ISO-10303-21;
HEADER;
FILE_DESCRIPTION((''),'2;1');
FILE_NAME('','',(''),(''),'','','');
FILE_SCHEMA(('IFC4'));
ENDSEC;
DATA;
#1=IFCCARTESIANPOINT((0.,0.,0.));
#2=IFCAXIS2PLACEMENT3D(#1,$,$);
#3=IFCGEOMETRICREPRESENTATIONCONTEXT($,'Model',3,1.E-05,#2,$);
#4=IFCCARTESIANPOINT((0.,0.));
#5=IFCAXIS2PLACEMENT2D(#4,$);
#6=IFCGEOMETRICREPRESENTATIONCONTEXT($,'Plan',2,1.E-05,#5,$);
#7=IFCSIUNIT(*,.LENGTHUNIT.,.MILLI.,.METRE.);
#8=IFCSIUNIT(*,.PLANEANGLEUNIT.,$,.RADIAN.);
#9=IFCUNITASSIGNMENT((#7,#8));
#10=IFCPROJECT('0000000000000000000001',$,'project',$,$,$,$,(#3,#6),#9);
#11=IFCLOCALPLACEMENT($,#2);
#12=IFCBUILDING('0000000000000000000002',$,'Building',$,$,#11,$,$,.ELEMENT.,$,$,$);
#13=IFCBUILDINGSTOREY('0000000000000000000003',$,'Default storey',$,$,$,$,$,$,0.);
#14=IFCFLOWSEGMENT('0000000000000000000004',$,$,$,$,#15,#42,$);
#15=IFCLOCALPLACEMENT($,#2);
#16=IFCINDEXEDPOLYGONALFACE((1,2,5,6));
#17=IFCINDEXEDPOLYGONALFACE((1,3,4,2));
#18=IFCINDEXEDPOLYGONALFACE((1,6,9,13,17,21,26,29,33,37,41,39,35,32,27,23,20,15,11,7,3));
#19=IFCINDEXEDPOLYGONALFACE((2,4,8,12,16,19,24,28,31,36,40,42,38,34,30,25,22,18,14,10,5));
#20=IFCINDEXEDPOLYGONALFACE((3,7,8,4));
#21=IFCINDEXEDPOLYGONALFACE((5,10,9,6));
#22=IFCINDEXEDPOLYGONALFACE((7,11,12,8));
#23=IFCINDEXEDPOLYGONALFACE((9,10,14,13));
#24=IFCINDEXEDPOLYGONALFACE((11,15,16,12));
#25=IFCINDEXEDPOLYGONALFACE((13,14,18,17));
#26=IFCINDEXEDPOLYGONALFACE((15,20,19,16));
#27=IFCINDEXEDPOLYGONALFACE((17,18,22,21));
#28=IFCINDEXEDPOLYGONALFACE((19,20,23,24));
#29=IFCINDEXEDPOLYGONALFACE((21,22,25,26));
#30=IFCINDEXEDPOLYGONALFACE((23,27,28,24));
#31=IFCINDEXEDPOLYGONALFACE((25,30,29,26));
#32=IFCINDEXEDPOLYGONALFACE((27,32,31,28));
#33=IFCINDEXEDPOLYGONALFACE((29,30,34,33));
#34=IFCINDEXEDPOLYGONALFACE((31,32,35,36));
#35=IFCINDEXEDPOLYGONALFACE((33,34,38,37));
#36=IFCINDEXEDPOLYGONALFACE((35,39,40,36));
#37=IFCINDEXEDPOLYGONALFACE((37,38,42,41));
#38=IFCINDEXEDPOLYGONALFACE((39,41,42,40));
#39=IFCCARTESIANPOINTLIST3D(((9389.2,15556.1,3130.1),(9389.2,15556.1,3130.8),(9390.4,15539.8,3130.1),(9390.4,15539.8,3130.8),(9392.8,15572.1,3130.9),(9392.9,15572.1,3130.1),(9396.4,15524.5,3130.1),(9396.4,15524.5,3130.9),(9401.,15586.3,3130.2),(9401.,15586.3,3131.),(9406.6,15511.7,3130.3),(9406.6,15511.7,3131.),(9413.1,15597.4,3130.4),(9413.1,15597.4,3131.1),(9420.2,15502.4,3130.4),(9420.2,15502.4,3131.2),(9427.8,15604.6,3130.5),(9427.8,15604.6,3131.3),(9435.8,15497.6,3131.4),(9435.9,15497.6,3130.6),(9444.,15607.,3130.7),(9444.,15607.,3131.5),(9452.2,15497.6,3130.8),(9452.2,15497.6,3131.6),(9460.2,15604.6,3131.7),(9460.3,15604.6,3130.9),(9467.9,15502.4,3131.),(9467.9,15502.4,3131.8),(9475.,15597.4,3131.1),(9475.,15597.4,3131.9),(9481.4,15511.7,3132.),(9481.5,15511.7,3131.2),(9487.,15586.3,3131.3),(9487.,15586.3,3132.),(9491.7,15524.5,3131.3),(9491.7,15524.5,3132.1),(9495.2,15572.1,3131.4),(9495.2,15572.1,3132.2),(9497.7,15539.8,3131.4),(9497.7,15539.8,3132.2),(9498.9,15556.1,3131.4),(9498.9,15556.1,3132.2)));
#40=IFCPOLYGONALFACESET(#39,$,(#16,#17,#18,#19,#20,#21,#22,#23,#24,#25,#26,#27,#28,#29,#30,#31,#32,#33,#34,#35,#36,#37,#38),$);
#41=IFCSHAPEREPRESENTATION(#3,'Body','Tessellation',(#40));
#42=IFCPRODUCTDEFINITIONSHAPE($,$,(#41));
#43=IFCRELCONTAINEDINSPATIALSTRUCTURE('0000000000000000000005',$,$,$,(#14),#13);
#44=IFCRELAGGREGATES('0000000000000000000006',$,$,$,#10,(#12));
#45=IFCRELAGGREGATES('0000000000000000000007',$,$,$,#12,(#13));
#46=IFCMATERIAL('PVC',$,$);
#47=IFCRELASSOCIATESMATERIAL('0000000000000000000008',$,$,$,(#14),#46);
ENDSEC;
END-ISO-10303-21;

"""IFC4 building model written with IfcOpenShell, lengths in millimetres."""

from ifc_helpers import new_model, si_unit, frame, origin, origin_2d, place, context, project, spatial, circle, extrude, material, element, save


model = new_model("IFC4")

# Units and contexts
model_context = context("Model", 3, precision=1e-05, world=origin())
plan_context = context("Plan", 2, precision=1e-05, world=origin_2d())
ifc_project = project(units=[si_unit("LENGTHUNIT", "METRE", prefix="MILLI"), si_unit("PLANEANGLEUNIT", "RADIAN")], contexts=[model_context, plan_context])

# Building, storey
placement = place(None, origin())
building = spatial("IfcBuilding", under=ifc_project, at=placement, Name="Building", CompositionType="ELEMENT")
storey = spatial("IfcBuildingStorey", under=building, Name="Default storey", Elevation=0.0)

# Flow segment
ifc_material = material(Name="PVC")
element("IfcFlowSegment", 1, at=placement, inside=storey, material=ifc_material, context=model_context, shape_type="SweptSolid", body=[
    extrude(circle(Radius=55.0, at=origin_2d()), frame((9444.0, 15552.0, 3130.7), z_axis=(-0.009623, 0.0, 0.765065), x_axis=(0.0, 9.623462, 0.0)), (0.0, 0.0, 1.0), 0.8),
])

save(model, "model.ifc")
